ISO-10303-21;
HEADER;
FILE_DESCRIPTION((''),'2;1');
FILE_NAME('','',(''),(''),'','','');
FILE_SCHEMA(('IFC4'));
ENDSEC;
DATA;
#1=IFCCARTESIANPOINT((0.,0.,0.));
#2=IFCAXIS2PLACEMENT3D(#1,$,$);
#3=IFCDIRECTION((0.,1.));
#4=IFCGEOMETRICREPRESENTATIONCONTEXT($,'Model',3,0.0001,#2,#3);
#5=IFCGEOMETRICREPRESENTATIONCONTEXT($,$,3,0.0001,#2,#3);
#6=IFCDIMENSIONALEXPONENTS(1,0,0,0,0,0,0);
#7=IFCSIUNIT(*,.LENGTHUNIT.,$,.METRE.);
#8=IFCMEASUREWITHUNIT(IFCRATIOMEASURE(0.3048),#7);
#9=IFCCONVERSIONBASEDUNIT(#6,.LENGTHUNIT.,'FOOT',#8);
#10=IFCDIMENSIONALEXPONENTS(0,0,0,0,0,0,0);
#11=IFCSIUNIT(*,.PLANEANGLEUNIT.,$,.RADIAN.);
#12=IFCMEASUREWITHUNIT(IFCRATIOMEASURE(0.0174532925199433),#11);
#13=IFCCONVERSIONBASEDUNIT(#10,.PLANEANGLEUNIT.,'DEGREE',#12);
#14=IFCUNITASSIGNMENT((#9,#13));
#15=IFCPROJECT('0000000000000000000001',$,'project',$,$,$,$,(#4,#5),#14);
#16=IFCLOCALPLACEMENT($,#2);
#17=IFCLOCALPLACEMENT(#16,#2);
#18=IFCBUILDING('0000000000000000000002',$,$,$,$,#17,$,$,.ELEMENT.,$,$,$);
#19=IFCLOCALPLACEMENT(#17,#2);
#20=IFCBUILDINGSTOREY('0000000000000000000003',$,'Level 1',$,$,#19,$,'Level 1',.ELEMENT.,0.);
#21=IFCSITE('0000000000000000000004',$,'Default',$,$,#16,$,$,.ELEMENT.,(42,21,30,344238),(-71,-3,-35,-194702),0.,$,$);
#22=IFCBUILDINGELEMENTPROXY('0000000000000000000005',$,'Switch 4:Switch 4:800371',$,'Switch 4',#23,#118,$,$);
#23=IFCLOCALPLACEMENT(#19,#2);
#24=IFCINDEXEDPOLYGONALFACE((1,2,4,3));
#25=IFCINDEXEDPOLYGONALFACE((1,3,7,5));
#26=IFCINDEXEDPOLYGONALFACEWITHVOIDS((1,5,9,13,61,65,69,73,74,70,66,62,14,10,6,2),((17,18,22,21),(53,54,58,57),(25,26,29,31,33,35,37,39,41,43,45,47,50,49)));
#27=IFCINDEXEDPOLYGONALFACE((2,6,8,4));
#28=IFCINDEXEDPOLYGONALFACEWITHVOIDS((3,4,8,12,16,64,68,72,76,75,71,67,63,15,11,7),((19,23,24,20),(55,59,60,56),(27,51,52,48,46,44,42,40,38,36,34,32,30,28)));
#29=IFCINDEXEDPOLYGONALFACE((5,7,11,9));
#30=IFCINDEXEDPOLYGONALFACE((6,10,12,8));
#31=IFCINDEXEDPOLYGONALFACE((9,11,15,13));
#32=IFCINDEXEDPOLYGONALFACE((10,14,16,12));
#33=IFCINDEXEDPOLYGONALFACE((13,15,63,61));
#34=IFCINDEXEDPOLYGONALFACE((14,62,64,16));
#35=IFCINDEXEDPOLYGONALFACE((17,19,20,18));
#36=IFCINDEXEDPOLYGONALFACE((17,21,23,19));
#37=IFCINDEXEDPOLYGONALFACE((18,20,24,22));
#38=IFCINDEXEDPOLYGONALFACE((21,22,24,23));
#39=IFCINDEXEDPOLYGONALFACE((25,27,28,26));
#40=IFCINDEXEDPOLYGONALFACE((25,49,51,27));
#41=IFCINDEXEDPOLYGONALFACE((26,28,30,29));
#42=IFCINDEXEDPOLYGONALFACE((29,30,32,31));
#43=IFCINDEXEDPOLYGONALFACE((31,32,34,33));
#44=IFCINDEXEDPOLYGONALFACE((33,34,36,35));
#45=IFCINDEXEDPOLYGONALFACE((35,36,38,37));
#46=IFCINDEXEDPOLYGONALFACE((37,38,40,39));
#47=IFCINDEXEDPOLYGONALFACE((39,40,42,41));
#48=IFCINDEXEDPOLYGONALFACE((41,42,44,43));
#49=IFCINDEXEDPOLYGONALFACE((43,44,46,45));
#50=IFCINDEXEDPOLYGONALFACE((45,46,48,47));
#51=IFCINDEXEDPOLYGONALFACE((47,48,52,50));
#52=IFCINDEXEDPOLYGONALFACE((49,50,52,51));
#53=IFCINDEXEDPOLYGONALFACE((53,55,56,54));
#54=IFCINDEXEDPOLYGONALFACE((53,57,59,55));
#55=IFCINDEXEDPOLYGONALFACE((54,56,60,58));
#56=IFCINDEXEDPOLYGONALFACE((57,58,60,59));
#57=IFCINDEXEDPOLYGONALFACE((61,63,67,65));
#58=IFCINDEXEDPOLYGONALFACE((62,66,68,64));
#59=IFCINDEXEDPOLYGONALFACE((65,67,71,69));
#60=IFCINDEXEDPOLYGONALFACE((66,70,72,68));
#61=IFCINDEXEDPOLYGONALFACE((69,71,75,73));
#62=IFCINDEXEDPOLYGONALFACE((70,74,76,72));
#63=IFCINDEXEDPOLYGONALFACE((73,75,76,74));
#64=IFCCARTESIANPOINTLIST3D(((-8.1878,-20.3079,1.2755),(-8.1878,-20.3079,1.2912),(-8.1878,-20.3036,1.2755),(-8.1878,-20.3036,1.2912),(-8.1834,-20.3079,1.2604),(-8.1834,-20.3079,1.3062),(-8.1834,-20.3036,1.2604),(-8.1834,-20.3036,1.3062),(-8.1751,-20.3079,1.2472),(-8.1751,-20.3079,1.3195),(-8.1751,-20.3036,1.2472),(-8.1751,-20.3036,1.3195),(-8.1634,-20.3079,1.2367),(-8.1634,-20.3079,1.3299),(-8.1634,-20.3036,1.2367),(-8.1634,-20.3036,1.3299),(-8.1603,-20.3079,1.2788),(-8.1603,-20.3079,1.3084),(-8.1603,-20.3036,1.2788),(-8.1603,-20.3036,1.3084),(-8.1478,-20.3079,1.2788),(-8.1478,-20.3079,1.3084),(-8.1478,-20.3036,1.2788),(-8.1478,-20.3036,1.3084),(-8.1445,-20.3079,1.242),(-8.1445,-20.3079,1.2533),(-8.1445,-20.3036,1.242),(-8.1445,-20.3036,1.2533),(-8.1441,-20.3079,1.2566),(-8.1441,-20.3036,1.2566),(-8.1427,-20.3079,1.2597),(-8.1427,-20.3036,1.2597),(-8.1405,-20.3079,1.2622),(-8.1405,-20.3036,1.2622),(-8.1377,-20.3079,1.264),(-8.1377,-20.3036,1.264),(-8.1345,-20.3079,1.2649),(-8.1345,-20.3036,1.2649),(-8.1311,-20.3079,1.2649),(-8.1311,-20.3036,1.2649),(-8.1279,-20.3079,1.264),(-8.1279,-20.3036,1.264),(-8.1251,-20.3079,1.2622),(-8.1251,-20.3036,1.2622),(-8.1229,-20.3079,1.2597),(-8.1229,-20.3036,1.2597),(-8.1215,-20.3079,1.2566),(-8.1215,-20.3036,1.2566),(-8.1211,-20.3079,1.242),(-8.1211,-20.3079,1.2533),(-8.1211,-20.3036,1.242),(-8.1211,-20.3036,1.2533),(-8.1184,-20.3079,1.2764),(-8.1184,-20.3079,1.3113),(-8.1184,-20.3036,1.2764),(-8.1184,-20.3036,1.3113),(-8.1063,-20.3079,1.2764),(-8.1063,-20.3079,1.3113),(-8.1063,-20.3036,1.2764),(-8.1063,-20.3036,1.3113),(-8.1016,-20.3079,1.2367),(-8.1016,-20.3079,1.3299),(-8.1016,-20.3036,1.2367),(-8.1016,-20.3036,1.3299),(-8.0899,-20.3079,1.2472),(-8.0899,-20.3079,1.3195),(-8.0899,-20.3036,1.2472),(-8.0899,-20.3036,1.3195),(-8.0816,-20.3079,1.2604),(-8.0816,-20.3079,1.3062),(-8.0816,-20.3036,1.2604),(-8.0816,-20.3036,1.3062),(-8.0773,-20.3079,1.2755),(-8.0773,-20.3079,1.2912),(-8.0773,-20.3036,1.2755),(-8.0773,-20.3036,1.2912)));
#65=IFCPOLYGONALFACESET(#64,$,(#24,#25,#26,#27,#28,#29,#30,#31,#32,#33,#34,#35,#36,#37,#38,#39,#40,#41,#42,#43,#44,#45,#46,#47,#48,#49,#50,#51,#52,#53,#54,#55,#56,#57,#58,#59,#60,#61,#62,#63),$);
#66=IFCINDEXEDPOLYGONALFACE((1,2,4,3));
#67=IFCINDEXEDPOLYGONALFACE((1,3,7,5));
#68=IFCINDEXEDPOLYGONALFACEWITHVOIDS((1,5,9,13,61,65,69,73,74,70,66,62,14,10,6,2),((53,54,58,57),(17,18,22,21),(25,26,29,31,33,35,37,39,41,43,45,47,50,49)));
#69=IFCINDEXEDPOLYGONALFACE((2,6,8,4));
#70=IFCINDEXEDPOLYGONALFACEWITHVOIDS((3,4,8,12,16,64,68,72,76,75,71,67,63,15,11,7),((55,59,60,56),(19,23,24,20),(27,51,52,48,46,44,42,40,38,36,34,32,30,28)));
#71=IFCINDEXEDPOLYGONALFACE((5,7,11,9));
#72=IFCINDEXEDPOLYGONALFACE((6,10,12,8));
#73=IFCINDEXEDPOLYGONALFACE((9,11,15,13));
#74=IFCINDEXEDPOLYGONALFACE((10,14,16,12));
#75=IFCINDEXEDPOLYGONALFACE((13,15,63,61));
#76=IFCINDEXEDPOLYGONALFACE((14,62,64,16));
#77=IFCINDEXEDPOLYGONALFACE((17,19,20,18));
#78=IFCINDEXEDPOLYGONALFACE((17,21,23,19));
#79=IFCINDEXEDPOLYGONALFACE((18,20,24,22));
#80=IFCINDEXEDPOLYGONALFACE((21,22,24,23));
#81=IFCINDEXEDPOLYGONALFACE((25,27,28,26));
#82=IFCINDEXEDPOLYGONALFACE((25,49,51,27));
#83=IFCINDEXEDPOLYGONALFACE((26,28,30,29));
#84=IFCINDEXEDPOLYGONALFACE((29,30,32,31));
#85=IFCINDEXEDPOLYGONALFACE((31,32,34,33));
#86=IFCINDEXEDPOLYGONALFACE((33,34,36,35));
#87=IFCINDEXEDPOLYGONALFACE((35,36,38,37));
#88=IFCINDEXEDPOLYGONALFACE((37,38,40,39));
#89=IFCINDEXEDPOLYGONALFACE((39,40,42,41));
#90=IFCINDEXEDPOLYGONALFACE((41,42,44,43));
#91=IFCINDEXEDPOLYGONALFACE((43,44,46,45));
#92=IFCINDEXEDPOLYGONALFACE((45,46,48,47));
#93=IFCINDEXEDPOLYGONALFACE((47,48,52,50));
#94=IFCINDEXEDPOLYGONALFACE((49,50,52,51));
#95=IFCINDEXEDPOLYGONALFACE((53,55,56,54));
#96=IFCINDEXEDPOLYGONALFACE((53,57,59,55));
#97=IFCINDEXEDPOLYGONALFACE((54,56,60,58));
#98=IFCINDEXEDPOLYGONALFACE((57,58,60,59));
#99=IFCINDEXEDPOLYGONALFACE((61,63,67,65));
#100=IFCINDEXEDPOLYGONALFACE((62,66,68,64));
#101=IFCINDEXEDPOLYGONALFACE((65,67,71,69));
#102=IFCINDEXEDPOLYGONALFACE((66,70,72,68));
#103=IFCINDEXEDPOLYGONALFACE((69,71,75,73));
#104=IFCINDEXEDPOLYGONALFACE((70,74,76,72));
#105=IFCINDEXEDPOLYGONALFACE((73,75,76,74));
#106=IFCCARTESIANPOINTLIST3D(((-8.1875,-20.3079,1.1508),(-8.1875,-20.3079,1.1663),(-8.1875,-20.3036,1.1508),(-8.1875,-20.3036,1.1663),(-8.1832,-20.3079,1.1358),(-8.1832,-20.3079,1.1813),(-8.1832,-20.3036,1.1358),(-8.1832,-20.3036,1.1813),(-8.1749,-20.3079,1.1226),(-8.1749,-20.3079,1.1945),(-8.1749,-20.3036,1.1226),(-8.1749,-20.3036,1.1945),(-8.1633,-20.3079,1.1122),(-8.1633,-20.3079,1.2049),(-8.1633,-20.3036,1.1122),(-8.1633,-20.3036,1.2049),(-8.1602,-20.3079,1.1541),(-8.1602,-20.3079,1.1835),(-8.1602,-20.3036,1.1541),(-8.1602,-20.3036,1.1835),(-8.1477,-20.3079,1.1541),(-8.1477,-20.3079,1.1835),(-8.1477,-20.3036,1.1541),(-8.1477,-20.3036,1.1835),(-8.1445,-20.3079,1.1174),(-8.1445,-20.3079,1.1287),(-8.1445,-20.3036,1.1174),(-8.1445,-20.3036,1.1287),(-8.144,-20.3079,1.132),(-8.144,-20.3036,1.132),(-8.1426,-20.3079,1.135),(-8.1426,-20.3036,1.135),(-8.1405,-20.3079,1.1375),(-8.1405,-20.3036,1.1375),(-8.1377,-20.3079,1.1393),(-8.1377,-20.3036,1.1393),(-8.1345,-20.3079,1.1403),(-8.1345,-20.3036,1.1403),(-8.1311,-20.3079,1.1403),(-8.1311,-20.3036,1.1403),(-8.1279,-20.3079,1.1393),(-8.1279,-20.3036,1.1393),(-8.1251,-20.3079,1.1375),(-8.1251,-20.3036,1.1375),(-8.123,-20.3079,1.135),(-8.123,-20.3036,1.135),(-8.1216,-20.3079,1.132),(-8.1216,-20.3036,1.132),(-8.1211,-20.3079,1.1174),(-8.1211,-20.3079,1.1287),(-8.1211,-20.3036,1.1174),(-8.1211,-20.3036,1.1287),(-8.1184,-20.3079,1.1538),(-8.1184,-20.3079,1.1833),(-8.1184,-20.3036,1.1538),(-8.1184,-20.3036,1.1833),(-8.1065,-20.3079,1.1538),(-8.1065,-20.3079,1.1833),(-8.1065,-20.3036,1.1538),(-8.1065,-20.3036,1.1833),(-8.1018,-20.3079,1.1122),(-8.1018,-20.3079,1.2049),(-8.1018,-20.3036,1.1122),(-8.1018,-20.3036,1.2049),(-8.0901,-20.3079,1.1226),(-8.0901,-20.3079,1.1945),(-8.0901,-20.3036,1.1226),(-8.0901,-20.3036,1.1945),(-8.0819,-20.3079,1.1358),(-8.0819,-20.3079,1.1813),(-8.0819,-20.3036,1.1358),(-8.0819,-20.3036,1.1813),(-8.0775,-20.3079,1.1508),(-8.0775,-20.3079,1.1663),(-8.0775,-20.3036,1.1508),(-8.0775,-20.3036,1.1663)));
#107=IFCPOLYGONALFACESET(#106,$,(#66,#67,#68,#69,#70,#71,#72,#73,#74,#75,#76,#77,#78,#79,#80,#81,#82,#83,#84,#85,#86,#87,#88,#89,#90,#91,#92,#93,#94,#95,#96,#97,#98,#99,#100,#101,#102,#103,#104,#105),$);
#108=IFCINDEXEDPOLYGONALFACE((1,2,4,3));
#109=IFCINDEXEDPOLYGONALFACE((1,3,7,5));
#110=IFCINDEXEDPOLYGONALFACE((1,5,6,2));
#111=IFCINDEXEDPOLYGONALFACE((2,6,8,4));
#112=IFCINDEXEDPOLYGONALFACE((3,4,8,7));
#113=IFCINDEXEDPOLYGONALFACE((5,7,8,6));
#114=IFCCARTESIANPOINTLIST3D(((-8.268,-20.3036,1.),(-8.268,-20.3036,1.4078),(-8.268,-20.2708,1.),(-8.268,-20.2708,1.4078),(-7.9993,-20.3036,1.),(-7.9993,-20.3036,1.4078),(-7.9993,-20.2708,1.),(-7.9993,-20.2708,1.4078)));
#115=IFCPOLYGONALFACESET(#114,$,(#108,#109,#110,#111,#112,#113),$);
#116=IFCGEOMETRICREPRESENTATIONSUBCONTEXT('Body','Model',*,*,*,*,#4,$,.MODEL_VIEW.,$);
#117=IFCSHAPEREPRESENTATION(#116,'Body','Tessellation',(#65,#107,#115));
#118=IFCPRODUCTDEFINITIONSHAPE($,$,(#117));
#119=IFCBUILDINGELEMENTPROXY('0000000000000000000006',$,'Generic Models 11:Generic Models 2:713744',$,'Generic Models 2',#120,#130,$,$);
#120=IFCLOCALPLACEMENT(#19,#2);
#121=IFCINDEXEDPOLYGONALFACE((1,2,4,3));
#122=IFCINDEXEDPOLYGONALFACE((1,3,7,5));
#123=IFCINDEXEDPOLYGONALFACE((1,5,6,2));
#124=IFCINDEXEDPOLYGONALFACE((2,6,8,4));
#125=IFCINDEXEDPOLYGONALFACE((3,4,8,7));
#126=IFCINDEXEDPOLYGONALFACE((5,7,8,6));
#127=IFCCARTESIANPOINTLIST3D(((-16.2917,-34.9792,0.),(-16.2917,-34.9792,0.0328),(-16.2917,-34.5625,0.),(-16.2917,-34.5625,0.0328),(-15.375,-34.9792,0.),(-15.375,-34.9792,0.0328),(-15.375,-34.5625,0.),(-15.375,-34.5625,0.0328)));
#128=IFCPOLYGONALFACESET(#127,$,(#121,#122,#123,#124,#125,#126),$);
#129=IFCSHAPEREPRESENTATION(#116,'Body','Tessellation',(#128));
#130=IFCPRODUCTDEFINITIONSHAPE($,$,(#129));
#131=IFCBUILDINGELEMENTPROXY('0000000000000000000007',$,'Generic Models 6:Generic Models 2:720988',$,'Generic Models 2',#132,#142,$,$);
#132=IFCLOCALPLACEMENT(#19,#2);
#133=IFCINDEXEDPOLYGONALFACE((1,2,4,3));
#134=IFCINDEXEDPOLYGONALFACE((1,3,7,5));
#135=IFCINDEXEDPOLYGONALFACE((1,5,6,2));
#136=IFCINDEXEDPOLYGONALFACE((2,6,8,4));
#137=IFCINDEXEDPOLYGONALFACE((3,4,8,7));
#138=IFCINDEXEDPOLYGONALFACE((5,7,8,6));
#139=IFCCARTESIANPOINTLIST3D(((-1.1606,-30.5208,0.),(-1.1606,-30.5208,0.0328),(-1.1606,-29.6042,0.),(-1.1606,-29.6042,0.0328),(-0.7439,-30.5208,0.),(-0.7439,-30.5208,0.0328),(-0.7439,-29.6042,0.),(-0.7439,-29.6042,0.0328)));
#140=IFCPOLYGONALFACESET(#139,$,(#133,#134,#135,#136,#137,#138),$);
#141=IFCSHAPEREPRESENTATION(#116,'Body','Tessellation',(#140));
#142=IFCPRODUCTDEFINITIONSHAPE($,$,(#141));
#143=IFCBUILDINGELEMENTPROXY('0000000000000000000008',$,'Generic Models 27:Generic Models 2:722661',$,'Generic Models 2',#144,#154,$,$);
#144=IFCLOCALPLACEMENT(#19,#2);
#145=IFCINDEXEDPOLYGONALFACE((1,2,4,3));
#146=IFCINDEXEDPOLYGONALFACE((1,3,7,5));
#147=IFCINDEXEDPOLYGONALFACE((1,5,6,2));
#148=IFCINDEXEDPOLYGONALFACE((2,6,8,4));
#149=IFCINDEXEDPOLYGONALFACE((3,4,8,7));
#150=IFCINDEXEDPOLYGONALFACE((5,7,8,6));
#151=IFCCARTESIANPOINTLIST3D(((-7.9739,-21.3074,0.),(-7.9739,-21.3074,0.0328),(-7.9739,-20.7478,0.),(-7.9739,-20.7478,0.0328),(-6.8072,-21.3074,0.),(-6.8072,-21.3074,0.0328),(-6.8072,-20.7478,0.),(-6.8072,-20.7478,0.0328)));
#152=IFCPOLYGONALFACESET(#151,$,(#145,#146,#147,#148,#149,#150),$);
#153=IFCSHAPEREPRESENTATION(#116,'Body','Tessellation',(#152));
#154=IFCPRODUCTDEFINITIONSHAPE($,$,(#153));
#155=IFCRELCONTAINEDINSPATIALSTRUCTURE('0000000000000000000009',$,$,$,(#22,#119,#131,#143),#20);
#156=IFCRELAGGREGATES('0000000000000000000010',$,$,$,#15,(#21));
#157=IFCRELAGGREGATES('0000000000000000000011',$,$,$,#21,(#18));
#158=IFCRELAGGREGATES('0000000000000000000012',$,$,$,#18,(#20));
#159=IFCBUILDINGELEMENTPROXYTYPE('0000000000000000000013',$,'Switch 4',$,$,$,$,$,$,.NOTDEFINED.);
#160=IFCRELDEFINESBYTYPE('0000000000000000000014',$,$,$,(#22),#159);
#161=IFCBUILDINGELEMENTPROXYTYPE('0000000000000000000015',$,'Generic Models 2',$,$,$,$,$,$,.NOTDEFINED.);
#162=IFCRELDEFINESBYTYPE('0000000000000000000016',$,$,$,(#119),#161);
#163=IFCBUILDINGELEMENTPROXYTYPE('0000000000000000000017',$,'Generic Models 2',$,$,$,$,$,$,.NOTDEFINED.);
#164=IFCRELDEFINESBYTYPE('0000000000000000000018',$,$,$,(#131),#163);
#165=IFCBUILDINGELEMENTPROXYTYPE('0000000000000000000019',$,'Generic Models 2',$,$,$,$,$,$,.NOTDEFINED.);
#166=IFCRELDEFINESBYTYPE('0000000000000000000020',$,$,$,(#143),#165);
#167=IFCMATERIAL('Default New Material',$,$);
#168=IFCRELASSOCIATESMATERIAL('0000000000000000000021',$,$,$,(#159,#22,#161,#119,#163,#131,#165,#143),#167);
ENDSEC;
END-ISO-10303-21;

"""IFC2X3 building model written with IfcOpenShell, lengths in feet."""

from ifc_helpers import new_model, entity, si_unit, converted_unit, direction, frame, frame_2d, origin, origin_2d_with_axis, place, context, subcontext, project, spatial, polyline, circle_curve, parameter, trimmed, segment, composite_curve, rectangle, outline, extrude, source, transform, mapped, material, type_object, type_shapes, element, save


model = new_model("IFC2X3")

# Units and contexts
model_context = context("Model", 3, precision=0.0001, world=origin(), true_north=direction((0.0, 1.0)))
context_of_model = context(None, 3, precision=0.0001, world=origin(), true_north=direction((0.0, 1.0)))
body_context = subcontext(model_context, "Body", "Model", "MODEL_VIEW")
ifc_project = project(units=[converted_unit("LENGTHUNIT", "FOOT", entity("IfcRatioMeasure", 0.3048), si_unit("LENGTHUNIT", "METRE"), dimensions=[1, 0, 0, 0, 0, 0, 0]), converted_unit("PLANEANGLEUNIT", "DEGREE", entity("IfcRatioMeasure", 0.0174532925199433), si_unit("PLANEANGLEUNIT", "RADIAN"), dimensions=[0, 0, 0, 0, 0, 0, 0])], contexts=[model_context, context_of_model])

# Site, building, storey
site_placement = place(None, origin())
site = spatial("IfcSite", under=ifc_project, at=site_placement, Name="Default", CompositionType="ELEMENT", RefLatitude=(42, 21, 30, 344238), RefLongitude=(-71, -3, -35, -194702), RefElevation=0.0)
building_placement = place(site_placement, origin())
building = spatial("IfcBuilding", under=site, at=building_placement, CompositionType="ELEMENT")
storey_placement = place(building_placement, origin())
storey = spatial("IfcBuildingStorey", under=building, at=storey_placement, Name="Level 1", LongName="Level 1", CompositionType="ELEMENT", Elevation=0.0)

# Shared definitions
ifc_material_1 = material(Name="Default New Material")

# Building element proxies
building_element_proxy_type_1 = type_object("IfcBuildingElementProxyType", Name="Switch 4", PredefinedType="NOTDEFINED", material=ifc_material_1)
shared_shape_1 = source(origin(), body_context, "Body", "SweptSolid", [
    extrude(outline(composite_curve([segment(polyline([(-0.0309, -0.0466), (0.0309, -0.0466)]), True, "CONTINUOUS"), segment(trimmed(circle_curve(frame_2d((-0.0003, 0.0), x_axis=(-1.0, 0.0)), 0.0561), [parameter(123.794741)], [parameter(236.205259)], True, "PARAMETER"), True, "CONTINUOUS"), segment(polyline([(0.0309, 0.0466), (-0.0309, 0.0466)]), True, "CONTINUOUS"), segment(trimmed(circle_curve(frame_2d((0.0003, 0.0), x_axis=(1.0, 0.0)), 0.0561), [parameter(123.794741)], [parameter(236.205259)], True, "PARAMETER"), True, "CONTINUOUS")], self_intersect=False), holes=[polyline([(0.0142, 0.0279), (0.0262, 0.0279), (0.0262, -0.0069), (0.0142, -0.0069), (0.0142, 0.0279)]), polyline([(-0.0153, 0.025), (-0.0153, -0.0045), (-0.0278, -0.0045), (-0.0278, 0.025), (-0.0153, 0.025)]), composite_curve([segment(polyline([(-0.012, -0.0413), (-0.012, -0.03)]), True, "CONTINUOUS"), segment(trimmed(circle_curve(frame_2d((-0.0003, -0.03), x_axis=(-1.0, 0.0)), 0.0117), [parameter(180.0)], [parameter(0.0)], True, "PARAMETER"), False, "CONTINUOUS"), segment(polyline([(0.0115, -0.03), (0.0115, -0.0413)]), True, "CONTINUOUS"), segment(polyline([(0.0115, -0.0413), (-0.012, -0.0413)]), True, "CONTINUOUS")], self_intersect=False)]), frame((-0.0011, 0.0328, 0.2833), z_axis=(0.0, 1.0, 0.0), x_axis=(-1.0, 0.0, 0.0)), (0.0, 0.0, 1.0), 0.0042),
    extrude(outline(composite_curve([segment(polyline([(-0.0308, -0.0464), (0.0308, -0.0464)]), True, "CONTINUOUS"), segment(trimmed(circle_curve(frame_2d((-0.0003, 0.0), x_axis=(-1.0, 0.0)), 0.0558), [parameter(123.794741)], [parameter(236.205259)], True, "PARAMETER"), True, "CONTINUOUS"), segment(polyline([(0.0308, 0.0464), (-0.0308, 0.0464)]), True, "CONTINUOUS"), segment(trimmed(circle_curve(frame_2d((0.0003, 0.0), x_axis=(1.0, 0.0)), 0.0558), [parameter(123.794741)], [parameter(236.205259)], True, "PARAMETER"), True, "CONTINUOUS")], self_intersect=False), holes=[polyline([(0.0141, 0.0247), (0.026, 0.0247), (0.026, -0.0047), (0.0141, -0.0047), (0.0141, 0.0247)]), polyline([(-0.0152, 0.0249), (-0.0152, -0.0045), (-0.0277, -0.0045), (-0.0277, 0.0249), (-0.0152, 0.0249)]), composite_curve([segment(polyline([(-0.012, -0.0411), (-0.012, -0.0299)]), True, "CONTINUOUS"), segment(trimmed(circle_curve(frame_2d((-0.0003, -0.0299), x_axis=(-1.0, 0.0)), 0.0117), [parameter(180.0)], [parameter(0.0)], True, "PARAMETER"), False, "CONTINUOUS"), segment(polyline([(0.0114, -0.0299), (0.0114, -0.0411)]), True, "CONTINUOUS"), segment(polyline([(0.0114, -0.0411), (-0.012, -0.0411)]), True, "CONTINUOUS")], self_intersect=False)]), frame((-0.0011, 0.0328, 0.1586), z_axis=(0.0, 1.0, 0.0), x_axis=(-1.0, 0.0, 0.0)), (0.0, 0.0, 1.0), 0.0042),
    extrude(rectangle(XDim=0.0328, YDim=0.2687, at=origin_2d_with_axis()), frame((0.0, 0.0164, 0.0), z_axis=(0.0, 0.0, 1.0), x_axis=(0.0, -1.0, 0.0)), (0.0, 0.0, 1.0), 0.4078),
])
type_shapes(building_element_proxy_type_1, [shared_shape_1])
for number, where, z_axis, x_axis, name in (
    (1, (-8.1336, -20.2708, 1.0), (0.0, 0.0, 1.0), (-1.0, 0.0, 0.0), "Switch 4:Switch 4:800371"),
):
    element("IfcBuildingElementProxy", number, at=place(storey_placement, frame(where, z_axis=z_axis, x_axis=x_axis)), inside=storey, type_object=building_element_proxy_type_1, material=ifc_material_1, Name=name, ObjectType="Switch 4", context=body_context, shape_type="MappedRepresentation", body=[
        mapped(shared_shape_1, transform((0.0, 0.0, 0.0), scale=1.0)),
    ])
building_element_proxy_type_2 = type_object("IfcBuildingElementProxyType", Name="Generic Models 2", PredefinedType="NOTDEFINED", material=ifc_material_1)
shared_shape_2 = source(origin(), body_context, "Body", "SweptSolid", [
    extrude(rectangle(XDim=0.9167, YDim=0.4167, at=frame_2d((0.0, 0.0), x_axis=(1.0, 0.0))), frame((0.4583, 0.2083, 0.0), z_axis=(0.0, 0.0, 1.0), x_axis=(-1.0, 0.0, 0.0)), (0.0, 0.0, 1.0), 0.0328),
])
type_shapes(building_element_proxy_type_2, [shared_shape_2])
proxy_1_placement = place(storey_placement, frame((-16.2917, -34.9792, 0.0)))
element("IfcBuildingElementProxy", 2, at=proxy_1_placement, inside=storey, type_object=building_element_proxy_type_2, material=ifc_material_1, Name="Generic Models 11:Generic Models 2:713744", ObjectType="Generic Models 2", context=body_context, shape_type="MappedRepresentation", body=[
    mapped(shared_shape_2, transform((0.0, 0.0, 0.0), scale=1.0)),
])
building_element_proxy_type_3 = type_object("IfcBuildingElementProxyType", Name="Generic Models 2", PredefinedType="NOTDEFINED", material=ifc_material_1)
shared_shape_3 = source(origin(), body_context, "Body", "SweptSolid", [
    extrude(rectangle(XDim=0.9167, YDim=0.4167, at=frame_2d((0.0, 0.0), x_axis=(1.0, 0.0))), frame((0.4583, 0.2083, 0.0), z_axis=(0.0, 0.0, 1.0), x_axis=(-1.0, 0.0, 0.0)), (0.0, 0.0, 1.0), 0.0328),
])
type_shapes(building_element_proxy_type_3, [shared_shape_3])
proxy_2_placement = place(storey_placement, frame((-0.7439, -30.5208, 0.0), z_axis=(0.0, 0.0, 1.0), x_axis=(0.0, 1.0, 0.0)))
element("IfcBuildingElementProxy", 3, at=proxy_2_placement, inside=storey, type_object=building_element_proxy_type_3, material=ifc_material_1, Name="Generic Models 6:Generic Models 2:720988", ObjectType="Generic Models 2", context=body_context, shape_type="MappedRepresentation", body=[
    mapped(shared_shape_3, transform((0.0, 0.0, 0.0), scale=1.0)),
])
building_element_proxy_type_4 = type_object("IfcBuildingElementProxyType", Name="Generic Models 2", PredefinedType="NOTDEFINED", material=ifc_material_1)
shared_shape_4 = source(origin(), body_context, "Body", "SweptSolid", [
    extrude(rectangle(XDim=1.1667, YDim=0.5596, at=frame_2d((0.0, 0.0), x_axis=(1.0, 0.0))), frame((0.5833, 0.2798, 0.0), z_axis=(0.0, 0.0, 1.0), x_axis=(-1.0, 0.0, 0.0)), (0.0, 0.0, 1.0), 0.0328),
])
type_shapes(building_element_proxy_type_4, [shared_shape_4])
proxy_3_placement = place(storey_placement, frame((-7.9739, -21.3074, 0.0)))
element("IfcBuildingElementProxy", 4, at=proxy_3_placement, inside=storey, type_object=building_element_proxy_type_4, material=ifc_material_1, Name="Generic Models 27:Generic Models 2:722661", ObjectType="Generic Models 2", context=body_context, shape_type="MappedRepresentation", body=[
    mapped(shared_shape_4, transform((0.0, 0.0, 0.0), scale=1.0)),
])

save(model, "model.ifc")
